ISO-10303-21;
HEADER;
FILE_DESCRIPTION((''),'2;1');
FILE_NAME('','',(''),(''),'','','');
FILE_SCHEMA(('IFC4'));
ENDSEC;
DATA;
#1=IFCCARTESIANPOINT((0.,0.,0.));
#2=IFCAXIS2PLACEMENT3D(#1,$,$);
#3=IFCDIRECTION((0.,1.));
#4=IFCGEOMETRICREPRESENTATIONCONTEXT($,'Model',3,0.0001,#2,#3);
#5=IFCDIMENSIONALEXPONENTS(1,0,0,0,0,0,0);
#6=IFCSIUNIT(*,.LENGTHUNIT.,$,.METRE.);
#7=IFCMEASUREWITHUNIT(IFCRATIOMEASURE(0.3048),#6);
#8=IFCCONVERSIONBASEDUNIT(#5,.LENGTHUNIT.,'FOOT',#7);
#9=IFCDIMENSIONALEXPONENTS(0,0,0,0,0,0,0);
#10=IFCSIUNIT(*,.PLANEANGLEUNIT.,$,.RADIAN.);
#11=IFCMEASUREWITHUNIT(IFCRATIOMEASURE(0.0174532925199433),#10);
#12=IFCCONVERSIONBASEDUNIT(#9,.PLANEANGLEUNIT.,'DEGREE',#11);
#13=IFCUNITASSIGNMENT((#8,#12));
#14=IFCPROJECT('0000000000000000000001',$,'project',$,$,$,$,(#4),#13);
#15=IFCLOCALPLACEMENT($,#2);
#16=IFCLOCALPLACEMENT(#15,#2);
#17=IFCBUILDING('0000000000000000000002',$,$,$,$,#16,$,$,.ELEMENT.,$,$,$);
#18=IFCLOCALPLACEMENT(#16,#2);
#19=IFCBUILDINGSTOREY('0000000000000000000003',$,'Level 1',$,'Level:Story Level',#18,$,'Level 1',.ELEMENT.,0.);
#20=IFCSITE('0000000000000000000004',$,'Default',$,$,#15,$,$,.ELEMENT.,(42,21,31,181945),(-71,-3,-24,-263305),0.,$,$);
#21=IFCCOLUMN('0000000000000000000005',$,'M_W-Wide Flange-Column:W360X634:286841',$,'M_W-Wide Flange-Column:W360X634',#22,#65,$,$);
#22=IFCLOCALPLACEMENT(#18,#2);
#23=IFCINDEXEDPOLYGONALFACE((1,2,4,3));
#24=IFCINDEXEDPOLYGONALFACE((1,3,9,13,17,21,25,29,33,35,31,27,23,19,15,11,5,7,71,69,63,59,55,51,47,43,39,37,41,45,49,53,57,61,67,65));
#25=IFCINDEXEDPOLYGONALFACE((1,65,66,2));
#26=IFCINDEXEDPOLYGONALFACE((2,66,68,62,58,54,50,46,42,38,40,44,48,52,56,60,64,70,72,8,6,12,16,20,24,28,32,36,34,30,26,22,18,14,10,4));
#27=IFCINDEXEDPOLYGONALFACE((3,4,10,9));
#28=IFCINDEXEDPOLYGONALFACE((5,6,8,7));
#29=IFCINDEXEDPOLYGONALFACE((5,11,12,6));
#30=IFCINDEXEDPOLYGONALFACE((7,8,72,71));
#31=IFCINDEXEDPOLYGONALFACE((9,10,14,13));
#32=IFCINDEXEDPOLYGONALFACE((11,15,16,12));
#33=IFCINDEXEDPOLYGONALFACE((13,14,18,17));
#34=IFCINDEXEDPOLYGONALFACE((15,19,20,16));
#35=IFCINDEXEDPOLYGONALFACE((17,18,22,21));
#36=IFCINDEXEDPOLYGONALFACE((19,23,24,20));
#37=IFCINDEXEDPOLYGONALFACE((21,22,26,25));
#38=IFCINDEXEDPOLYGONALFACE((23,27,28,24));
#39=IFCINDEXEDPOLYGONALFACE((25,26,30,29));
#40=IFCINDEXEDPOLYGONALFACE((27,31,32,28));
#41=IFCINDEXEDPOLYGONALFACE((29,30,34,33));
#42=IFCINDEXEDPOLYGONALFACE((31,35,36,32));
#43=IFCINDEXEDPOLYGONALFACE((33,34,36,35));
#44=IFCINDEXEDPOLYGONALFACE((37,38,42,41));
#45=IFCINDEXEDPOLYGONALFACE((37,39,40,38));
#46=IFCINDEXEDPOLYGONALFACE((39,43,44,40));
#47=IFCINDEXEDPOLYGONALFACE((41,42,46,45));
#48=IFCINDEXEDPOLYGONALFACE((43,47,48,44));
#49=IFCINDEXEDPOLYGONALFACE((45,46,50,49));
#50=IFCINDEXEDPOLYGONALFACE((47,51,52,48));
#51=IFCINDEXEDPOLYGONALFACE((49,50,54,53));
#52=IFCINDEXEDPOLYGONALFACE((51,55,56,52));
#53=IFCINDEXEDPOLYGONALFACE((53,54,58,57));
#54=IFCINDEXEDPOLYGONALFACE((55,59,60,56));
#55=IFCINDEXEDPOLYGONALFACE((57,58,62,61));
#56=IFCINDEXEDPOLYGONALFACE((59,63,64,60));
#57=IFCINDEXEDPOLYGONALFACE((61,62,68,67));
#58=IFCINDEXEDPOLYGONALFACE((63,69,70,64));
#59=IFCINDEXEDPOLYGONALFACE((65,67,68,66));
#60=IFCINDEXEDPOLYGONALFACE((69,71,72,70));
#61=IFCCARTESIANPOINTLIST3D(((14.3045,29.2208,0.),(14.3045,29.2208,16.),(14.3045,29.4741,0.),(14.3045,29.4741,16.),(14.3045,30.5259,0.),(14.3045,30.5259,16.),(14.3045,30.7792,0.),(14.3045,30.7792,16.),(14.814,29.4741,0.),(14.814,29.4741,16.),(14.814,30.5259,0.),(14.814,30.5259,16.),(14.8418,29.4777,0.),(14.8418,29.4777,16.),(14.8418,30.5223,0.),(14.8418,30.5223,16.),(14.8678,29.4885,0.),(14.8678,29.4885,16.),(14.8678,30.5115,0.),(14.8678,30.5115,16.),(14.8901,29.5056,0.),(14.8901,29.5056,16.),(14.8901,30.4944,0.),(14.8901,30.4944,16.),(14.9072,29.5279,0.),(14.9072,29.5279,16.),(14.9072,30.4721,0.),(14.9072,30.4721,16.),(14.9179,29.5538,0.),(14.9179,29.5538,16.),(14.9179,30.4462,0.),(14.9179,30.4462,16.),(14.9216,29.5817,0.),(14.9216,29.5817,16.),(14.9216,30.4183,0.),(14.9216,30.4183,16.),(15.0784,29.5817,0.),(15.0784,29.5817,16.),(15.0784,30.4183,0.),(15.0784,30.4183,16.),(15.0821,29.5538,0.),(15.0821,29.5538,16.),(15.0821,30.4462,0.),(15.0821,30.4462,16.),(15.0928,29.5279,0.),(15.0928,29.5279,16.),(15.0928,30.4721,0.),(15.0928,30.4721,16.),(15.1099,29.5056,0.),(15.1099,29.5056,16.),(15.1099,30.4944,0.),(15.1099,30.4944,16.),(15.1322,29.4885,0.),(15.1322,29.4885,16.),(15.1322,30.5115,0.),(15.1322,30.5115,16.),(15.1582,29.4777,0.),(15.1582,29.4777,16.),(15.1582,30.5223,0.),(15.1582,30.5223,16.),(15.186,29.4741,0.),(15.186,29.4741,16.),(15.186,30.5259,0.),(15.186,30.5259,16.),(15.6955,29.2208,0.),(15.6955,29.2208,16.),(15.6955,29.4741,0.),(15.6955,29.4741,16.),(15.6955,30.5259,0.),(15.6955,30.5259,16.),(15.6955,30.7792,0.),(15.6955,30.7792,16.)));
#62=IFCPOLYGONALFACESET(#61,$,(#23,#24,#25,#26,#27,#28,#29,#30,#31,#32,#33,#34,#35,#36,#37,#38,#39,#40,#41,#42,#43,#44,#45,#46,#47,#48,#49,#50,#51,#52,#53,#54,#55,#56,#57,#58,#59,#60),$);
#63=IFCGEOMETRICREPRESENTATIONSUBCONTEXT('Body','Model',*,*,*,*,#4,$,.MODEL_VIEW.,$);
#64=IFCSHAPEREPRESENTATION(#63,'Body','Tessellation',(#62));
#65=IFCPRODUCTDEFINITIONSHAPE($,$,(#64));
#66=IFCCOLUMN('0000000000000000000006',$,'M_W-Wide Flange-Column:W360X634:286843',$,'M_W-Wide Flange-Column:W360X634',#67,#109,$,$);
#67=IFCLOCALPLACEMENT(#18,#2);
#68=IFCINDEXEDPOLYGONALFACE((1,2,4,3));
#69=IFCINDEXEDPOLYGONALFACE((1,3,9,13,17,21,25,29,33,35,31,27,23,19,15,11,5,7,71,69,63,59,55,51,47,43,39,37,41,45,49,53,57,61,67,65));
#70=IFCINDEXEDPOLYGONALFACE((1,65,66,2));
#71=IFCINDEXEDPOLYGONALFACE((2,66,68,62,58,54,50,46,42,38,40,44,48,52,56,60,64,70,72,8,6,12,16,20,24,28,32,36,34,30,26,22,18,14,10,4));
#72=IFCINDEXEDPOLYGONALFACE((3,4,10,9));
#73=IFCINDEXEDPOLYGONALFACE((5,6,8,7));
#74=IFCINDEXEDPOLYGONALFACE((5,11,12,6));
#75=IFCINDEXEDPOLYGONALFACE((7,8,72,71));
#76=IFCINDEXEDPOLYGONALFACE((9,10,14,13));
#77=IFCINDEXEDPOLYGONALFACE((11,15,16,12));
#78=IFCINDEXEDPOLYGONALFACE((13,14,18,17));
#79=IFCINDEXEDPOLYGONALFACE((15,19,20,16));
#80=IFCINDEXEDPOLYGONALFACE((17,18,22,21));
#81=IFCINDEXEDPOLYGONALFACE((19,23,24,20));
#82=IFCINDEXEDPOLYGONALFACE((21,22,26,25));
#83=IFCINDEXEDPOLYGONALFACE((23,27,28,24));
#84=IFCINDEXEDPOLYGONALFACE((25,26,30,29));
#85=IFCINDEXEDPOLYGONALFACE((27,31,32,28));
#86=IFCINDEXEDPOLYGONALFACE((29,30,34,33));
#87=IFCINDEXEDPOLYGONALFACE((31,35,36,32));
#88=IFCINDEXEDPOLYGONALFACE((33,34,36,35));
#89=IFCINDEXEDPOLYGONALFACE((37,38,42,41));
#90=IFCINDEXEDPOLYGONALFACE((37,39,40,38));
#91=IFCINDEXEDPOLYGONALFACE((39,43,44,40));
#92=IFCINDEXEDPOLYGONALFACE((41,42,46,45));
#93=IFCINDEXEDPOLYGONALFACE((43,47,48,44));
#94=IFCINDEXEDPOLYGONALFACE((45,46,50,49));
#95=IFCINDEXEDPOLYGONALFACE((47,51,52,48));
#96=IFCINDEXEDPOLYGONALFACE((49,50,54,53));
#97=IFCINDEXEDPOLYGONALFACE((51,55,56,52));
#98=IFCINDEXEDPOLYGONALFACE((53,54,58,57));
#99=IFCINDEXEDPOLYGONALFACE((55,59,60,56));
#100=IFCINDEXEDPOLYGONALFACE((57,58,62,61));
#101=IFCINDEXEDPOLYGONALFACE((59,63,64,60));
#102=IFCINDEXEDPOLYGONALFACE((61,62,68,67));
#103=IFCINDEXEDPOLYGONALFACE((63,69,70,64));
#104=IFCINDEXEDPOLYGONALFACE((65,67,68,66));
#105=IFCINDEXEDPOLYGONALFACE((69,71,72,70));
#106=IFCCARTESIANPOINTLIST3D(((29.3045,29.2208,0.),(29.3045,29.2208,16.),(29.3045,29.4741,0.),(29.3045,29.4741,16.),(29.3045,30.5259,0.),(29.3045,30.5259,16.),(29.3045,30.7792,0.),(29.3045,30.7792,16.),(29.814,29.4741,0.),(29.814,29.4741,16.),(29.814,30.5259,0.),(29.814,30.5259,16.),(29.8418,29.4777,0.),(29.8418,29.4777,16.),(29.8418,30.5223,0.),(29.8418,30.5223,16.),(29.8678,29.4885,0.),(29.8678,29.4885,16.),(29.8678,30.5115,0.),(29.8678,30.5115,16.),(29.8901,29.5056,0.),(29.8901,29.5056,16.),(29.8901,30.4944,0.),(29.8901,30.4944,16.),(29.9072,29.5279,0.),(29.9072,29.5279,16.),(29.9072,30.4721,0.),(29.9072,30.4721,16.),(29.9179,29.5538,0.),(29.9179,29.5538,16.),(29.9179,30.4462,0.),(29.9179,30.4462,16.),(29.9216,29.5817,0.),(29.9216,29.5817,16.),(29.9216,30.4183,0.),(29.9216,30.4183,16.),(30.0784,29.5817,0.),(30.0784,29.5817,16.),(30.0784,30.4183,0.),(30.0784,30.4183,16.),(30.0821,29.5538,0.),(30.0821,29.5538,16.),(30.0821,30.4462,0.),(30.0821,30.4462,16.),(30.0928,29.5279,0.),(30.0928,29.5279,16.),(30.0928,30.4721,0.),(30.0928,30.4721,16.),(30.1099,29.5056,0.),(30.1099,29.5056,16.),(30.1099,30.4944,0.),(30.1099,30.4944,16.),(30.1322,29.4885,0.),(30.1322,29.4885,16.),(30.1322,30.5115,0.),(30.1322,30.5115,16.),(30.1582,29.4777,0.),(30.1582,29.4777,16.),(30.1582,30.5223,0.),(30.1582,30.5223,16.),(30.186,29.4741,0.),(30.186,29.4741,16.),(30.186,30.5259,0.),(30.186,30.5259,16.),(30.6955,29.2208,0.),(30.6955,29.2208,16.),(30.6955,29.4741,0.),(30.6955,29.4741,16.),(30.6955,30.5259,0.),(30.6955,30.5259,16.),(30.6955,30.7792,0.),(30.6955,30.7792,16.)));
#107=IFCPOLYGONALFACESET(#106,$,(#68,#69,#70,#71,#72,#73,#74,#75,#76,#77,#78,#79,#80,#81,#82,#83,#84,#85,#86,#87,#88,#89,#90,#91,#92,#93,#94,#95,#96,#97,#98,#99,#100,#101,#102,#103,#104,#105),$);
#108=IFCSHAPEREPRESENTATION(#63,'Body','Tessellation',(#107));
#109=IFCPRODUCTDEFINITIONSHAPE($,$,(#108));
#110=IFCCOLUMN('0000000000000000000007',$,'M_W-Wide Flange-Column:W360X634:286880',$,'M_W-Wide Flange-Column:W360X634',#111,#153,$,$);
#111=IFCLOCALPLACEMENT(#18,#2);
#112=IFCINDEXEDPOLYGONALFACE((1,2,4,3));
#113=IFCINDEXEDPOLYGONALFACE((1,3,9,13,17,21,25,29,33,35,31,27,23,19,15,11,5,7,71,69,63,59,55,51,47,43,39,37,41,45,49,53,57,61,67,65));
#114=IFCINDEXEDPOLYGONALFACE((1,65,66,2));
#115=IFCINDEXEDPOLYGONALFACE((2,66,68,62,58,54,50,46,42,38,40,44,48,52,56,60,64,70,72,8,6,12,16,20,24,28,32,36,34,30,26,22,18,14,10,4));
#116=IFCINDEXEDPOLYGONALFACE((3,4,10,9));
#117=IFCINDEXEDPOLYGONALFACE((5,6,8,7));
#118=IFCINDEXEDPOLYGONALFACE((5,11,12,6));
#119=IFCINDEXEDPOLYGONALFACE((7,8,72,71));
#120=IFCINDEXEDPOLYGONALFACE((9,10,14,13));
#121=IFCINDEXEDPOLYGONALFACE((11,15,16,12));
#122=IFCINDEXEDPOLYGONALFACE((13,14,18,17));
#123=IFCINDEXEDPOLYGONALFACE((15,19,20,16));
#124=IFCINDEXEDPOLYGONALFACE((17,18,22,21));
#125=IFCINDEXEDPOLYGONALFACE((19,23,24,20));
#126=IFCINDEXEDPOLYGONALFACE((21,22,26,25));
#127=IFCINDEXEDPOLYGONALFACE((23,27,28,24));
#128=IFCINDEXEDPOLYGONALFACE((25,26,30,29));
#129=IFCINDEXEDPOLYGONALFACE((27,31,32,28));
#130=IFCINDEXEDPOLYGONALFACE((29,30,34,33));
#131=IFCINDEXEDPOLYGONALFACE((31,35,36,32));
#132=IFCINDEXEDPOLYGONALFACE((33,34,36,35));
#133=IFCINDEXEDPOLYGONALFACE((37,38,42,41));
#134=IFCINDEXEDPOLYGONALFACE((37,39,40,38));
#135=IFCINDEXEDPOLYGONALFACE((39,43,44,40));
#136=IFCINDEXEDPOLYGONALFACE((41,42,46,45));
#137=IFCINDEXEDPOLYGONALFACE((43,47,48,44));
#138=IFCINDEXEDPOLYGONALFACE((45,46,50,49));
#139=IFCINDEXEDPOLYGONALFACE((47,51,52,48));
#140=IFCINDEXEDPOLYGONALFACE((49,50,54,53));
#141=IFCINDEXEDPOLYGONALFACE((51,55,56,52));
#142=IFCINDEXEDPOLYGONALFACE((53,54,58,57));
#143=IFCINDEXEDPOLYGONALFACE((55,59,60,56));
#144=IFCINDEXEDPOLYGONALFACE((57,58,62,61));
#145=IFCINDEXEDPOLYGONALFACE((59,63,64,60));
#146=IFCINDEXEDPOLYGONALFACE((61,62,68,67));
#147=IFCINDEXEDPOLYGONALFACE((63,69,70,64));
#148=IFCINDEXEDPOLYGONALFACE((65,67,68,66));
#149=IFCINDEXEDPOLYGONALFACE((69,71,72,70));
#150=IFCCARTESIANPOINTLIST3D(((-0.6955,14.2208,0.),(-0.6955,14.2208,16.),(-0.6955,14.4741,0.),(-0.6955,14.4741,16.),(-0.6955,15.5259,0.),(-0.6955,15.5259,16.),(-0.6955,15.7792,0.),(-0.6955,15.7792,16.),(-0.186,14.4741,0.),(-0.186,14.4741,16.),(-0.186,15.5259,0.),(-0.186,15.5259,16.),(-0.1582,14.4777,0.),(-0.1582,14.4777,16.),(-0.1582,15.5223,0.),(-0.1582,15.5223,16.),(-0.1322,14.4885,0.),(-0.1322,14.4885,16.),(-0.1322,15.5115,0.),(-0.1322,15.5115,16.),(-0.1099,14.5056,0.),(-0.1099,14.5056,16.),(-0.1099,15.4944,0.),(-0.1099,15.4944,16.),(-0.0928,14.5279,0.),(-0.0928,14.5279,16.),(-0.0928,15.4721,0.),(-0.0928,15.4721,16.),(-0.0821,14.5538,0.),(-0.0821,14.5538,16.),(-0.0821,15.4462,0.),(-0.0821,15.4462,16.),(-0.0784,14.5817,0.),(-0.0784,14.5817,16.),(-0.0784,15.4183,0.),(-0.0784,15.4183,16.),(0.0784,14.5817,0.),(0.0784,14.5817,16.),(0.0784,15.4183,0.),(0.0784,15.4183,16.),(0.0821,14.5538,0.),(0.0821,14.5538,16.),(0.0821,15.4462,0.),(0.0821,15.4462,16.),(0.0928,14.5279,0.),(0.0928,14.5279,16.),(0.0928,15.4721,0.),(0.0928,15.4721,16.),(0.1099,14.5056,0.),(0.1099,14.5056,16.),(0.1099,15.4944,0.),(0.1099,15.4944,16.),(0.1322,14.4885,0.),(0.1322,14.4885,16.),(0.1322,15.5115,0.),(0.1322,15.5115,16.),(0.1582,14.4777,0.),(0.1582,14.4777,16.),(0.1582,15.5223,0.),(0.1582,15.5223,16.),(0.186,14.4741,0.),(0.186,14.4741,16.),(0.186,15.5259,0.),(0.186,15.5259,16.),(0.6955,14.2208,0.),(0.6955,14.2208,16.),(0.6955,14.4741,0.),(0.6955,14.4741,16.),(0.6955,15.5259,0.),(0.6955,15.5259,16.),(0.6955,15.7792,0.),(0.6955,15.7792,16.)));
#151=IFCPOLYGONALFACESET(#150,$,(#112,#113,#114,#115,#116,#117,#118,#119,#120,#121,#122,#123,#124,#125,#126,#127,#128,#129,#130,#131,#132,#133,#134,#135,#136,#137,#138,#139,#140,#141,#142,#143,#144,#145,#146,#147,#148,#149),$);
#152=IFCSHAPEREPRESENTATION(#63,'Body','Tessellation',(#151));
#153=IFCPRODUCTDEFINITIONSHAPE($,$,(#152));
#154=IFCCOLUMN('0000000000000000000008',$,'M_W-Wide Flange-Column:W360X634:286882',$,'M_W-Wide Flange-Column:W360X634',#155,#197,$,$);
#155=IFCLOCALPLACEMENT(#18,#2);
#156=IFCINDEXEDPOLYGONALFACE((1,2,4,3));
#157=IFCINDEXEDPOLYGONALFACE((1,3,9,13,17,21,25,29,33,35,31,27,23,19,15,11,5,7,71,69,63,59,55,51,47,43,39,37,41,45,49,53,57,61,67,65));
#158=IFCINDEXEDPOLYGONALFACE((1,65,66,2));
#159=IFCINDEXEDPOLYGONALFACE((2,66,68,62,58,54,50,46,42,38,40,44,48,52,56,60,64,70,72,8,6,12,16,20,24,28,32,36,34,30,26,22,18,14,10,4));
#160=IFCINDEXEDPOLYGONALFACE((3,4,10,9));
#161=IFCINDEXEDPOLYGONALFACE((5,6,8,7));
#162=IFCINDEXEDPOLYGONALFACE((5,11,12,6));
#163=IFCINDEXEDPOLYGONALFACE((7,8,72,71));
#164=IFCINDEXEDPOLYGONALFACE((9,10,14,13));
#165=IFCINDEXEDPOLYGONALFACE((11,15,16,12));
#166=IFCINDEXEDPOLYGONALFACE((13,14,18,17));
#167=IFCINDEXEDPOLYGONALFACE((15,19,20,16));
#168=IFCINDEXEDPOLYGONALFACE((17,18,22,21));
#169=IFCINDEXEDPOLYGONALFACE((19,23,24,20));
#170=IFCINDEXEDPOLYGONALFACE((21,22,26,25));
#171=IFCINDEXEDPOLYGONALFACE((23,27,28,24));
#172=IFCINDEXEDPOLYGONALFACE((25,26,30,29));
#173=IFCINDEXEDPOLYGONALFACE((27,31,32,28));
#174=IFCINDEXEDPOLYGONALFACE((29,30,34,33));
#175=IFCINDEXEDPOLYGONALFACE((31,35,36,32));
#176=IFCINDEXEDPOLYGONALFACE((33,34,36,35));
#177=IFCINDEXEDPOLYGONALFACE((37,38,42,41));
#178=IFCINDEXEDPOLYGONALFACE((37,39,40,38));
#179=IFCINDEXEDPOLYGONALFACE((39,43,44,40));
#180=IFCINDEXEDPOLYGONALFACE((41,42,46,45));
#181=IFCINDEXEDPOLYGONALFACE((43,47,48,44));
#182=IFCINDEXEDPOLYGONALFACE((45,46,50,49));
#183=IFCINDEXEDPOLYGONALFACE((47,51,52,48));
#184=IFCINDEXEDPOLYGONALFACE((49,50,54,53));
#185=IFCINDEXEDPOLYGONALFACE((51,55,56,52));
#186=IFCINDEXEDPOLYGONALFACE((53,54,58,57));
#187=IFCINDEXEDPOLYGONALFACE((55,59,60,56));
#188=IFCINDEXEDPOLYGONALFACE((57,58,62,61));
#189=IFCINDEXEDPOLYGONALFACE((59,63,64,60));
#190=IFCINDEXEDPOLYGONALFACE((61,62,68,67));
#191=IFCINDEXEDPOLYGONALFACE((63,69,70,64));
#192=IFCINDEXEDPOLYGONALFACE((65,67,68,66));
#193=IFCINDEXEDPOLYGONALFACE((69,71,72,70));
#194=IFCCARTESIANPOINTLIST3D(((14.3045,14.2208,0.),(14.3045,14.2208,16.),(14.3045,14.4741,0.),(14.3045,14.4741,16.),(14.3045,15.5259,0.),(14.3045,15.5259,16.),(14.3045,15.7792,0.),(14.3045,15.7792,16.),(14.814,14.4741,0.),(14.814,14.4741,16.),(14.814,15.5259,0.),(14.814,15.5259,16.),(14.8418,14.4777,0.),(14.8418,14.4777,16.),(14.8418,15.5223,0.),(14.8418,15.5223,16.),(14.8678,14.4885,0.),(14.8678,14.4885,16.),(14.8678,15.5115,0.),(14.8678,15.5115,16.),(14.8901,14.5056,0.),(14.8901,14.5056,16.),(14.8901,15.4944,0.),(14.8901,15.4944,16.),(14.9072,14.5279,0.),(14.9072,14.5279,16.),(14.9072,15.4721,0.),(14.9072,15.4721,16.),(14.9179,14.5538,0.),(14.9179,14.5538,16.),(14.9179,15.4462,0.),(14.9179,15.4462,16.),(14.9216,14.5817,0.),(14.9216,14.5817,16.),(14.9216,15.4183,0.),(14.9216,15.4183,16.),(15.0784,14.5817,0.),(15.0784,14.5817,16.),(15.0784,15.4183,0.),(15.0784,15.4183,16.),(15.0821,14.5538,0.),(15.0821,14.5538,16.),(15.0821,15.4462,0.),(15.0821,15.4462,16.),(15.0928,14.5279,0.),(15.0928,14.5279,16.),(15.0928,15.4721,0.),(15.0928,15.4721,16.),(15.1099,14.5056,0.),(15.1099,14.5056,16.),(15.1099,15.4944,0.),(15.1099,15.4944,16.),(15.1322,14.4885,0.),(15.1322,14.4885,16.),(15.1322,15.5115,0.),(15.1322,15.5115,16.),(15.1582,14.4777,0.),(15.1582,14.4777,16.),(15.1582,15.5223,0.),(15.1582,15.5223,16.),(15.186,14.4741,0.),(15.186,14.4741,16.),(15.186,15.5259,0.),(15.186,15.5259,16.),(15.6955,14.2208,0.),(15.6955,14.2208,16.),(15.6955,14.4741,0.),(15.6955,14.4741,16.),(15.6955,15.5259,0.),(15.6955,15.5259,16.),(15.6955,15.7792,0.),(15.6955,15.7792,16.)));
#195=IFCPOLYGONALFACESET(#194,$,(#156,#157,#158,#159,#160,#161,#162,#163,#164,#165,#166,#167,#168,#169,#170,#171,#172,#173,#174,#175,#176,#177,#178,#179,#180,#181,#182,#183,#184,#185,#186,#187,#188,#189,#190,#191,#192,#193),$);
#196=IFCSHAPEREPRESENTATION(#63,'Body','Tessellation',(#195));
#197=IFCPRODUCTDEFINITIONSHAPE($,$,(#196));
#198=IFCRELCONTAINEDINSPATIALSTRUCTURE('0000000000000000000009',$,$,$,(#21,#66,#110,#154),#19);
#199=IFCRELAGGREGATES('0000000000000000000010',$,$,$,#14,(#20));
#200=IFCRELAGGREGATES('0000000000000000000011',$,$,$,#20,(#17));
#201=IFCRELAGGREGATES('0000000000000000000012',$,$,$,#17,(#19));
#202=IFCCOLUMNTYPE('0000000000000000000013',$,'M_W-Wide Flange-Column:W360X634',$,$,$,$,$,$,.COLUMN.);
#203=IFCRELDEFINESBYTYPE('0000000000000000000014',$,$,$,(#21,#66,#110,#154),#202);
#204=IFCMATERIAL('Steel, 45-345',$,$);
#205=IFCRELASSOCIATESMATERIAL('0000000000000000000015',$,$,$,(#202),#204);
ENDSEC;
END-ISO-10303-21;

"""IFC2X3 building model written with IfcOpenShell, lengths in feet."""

from ifc_helpers import new_model, entity, si_unit, converted_unit, direction, frame, frame_2d, origin, place, context, subcontext, project, spatial, polyline, circle_curve, parameter, trimmed, segment, composite_curve, outline, extrude, source, transform, mapped, material, type_object, type_shapes, element, save


model = new_model("IFC2X3")

# Units and contexts
model_context = context("Model", 3, precision=0.0001, world=origin(), true_north=direction((0.0, 1.0)))
body_context = subcontext(model_context, "Body", "Model", "MODEL_VIEW")
ifc_project = project(units=[converted_unit("LENGTHUNIT", "FOOT", entity("IfcRatioMeasure", 0.3048), si_unit("LENGTHUNIT", "METRE"), dimensions=[1, 0, 0, 0, 0, 0, 0]), converted_unit("PLANEANGLEUNIT", "DEGREE", entity("IfcRatioMeasure", 0.0174532925199433), si_unit("PLANEANGLEUNIT", "RADIAN"), dimensions=[0, 0, 0, 0, 0, 0, 0])], contexts=[model_context])

# Site, building, storey
site_placement = place(None, origin())
site = spatial("IfcSite", under=ifc_project, at=site_placement, Name="Default", CompositionType="ELEMENT", RefLatitude=(42, 21, 31, 181945), RefLongitude=(-71, -3, -24, -263305), RefElevation=0.0)
building_placement = place(site_placement, origin())
building = spatial("IfcBuilding", under=site, at=building_placement, CompositionType="ELEMENT")
storey_placement = place(building_placement, origin())
storey = spatial("IfcBuildingStorey", under=building, at=storey_placement, Name="Level 1", ObjectType="Level:Story Level", LongName="Level 1", CompositionType="ELEMENT", Elevation=0.0)

# Columns
ifc_material = material(Name="Steel, 45-345")
column_type = type_object("IfcColumnType", Name="M_W-Wide Flange-Column:W360X634", PredefinedType="COLUMN", material=ifc_material)
shared_shape = source(origin(), body_context, "Body", "SweptSolid", [
    extrude(outline(composite_curve([segment(polyline([(0.5259, -0.6955), (0.7792, -0.6955)]), True, "CONTINUOUS"), segment(polyline([(0.7792, -0.6955), (0.7792, 0.6955)]), True, "CONTINUOUS"), segment(polyline([(0.7792, 0.6955), (0.5259, 0.6955)]), True, "CONTINUOUS"), segment(polyline([(0.5259, 0.6955), (0.5259, 0.186)]), True, "CONTINUOUS"), segment(trimmed(circle_curve(frame_2d((0.4183, 0.186), x_axis=(1.0, 0.0)), 0.1076), [parameter(270.0)], [parameter(0.0)], True, "PARAMETER"), False, "CONTINUOUS"), segment(polyline([(0.4183, 0.0784), (-0.4183, 0.0784)]), True, "CONTINUOUS"), segment(trimmed(circle_curve(frame_2d((-0.4183, 0.186), x_axis=(0.0, -1.0)), 0.1076), [parameter(270.0)], [parameter(0.0)], True, "PARAMETER"), False, "CONTINUOUS"), segment(polyline([(-0.5259, 0.186), (-0.5259, 0.6955)]), True, "CONTINUOUS"), segment(polyline([(-0.5259, 0.6955), (-0.7792, 0.6955)]), True, "CONTINUOUS"), segment(polyline([(-0.7792, 0.6955), (-0.7792, -0.6955)]), True, "CONTINUOUS"), segment(polyline([(-0.7792, -0.6955), (-0.5259, -0.6955)]), True, "CONTINUOUS"), segment(polyline([(-0.5259, -0.6955), (-0.5259, -0.186)]), True, "CONTINUOUS"), segment(trimmed(circle_curve(frame_2d((-0.4183, -0.186), x_axis=(-1.0, 0.0)), 0.1076), [parameter(270.0)], [parameter(0.0)], True, "PARAMETER"), False, "CONTINUOUS"), segment(polyline([(-0.4183, -0.0784), (0.4183, -0.0784)]), True, "CONTINUOUS"), segment(trimmed(circle_curve(frame_2d((0.4183, -0.186), x_axis=(0.0, 1.0)), 0.1076), [parameter(270.0)], [parameter(0.0)], True, "PARAMETER"), False, "CONTINUOUS"), segment(polyline([(0.5259, -0.186), (0.5259, -0.6955)]), True, "CONTINUOUS")], self_intersect=False)), frame((0.0, 0.0, 0.0), z_axis=(0.0, 0.0, 1.0), x_axis=(0.0, -1.0, 0.0)), (0.0, 0.0, 1.0), 16.0),
])
type_shapes(column_type, [shared_shape])
for number, where, name in (
    (1, (15.0, 30.0, 0.0), "M_W-Wide Flange-Column:W360X634:286841"),
    (2, (30.0, 30.0, 0.0), "M_W-Wide Flange-Column:W360X634:286843"),
    (3, (0.0, 15.0, 0.0), "M_W-Wide Flange-Column:W360X634:286880"),
    (4, (15.0, 15.0, 0.0), "M_W-Wide Flange-Column:W360X634:286882"),
):
    element("IfcColumn", number, at=place(storey_placement, frame(where)), inside=storey, type_object=column_type, Name=name, ObjectType="M_W-Wide Flange-Column:W360X634", context=body_context, shape_type="MappedRepresentation", body=[
        mapped(shared_shape, transform((0.0, 0.0, 0.0), scale=1.0)),
    ])

save(model, "model.ifc")
